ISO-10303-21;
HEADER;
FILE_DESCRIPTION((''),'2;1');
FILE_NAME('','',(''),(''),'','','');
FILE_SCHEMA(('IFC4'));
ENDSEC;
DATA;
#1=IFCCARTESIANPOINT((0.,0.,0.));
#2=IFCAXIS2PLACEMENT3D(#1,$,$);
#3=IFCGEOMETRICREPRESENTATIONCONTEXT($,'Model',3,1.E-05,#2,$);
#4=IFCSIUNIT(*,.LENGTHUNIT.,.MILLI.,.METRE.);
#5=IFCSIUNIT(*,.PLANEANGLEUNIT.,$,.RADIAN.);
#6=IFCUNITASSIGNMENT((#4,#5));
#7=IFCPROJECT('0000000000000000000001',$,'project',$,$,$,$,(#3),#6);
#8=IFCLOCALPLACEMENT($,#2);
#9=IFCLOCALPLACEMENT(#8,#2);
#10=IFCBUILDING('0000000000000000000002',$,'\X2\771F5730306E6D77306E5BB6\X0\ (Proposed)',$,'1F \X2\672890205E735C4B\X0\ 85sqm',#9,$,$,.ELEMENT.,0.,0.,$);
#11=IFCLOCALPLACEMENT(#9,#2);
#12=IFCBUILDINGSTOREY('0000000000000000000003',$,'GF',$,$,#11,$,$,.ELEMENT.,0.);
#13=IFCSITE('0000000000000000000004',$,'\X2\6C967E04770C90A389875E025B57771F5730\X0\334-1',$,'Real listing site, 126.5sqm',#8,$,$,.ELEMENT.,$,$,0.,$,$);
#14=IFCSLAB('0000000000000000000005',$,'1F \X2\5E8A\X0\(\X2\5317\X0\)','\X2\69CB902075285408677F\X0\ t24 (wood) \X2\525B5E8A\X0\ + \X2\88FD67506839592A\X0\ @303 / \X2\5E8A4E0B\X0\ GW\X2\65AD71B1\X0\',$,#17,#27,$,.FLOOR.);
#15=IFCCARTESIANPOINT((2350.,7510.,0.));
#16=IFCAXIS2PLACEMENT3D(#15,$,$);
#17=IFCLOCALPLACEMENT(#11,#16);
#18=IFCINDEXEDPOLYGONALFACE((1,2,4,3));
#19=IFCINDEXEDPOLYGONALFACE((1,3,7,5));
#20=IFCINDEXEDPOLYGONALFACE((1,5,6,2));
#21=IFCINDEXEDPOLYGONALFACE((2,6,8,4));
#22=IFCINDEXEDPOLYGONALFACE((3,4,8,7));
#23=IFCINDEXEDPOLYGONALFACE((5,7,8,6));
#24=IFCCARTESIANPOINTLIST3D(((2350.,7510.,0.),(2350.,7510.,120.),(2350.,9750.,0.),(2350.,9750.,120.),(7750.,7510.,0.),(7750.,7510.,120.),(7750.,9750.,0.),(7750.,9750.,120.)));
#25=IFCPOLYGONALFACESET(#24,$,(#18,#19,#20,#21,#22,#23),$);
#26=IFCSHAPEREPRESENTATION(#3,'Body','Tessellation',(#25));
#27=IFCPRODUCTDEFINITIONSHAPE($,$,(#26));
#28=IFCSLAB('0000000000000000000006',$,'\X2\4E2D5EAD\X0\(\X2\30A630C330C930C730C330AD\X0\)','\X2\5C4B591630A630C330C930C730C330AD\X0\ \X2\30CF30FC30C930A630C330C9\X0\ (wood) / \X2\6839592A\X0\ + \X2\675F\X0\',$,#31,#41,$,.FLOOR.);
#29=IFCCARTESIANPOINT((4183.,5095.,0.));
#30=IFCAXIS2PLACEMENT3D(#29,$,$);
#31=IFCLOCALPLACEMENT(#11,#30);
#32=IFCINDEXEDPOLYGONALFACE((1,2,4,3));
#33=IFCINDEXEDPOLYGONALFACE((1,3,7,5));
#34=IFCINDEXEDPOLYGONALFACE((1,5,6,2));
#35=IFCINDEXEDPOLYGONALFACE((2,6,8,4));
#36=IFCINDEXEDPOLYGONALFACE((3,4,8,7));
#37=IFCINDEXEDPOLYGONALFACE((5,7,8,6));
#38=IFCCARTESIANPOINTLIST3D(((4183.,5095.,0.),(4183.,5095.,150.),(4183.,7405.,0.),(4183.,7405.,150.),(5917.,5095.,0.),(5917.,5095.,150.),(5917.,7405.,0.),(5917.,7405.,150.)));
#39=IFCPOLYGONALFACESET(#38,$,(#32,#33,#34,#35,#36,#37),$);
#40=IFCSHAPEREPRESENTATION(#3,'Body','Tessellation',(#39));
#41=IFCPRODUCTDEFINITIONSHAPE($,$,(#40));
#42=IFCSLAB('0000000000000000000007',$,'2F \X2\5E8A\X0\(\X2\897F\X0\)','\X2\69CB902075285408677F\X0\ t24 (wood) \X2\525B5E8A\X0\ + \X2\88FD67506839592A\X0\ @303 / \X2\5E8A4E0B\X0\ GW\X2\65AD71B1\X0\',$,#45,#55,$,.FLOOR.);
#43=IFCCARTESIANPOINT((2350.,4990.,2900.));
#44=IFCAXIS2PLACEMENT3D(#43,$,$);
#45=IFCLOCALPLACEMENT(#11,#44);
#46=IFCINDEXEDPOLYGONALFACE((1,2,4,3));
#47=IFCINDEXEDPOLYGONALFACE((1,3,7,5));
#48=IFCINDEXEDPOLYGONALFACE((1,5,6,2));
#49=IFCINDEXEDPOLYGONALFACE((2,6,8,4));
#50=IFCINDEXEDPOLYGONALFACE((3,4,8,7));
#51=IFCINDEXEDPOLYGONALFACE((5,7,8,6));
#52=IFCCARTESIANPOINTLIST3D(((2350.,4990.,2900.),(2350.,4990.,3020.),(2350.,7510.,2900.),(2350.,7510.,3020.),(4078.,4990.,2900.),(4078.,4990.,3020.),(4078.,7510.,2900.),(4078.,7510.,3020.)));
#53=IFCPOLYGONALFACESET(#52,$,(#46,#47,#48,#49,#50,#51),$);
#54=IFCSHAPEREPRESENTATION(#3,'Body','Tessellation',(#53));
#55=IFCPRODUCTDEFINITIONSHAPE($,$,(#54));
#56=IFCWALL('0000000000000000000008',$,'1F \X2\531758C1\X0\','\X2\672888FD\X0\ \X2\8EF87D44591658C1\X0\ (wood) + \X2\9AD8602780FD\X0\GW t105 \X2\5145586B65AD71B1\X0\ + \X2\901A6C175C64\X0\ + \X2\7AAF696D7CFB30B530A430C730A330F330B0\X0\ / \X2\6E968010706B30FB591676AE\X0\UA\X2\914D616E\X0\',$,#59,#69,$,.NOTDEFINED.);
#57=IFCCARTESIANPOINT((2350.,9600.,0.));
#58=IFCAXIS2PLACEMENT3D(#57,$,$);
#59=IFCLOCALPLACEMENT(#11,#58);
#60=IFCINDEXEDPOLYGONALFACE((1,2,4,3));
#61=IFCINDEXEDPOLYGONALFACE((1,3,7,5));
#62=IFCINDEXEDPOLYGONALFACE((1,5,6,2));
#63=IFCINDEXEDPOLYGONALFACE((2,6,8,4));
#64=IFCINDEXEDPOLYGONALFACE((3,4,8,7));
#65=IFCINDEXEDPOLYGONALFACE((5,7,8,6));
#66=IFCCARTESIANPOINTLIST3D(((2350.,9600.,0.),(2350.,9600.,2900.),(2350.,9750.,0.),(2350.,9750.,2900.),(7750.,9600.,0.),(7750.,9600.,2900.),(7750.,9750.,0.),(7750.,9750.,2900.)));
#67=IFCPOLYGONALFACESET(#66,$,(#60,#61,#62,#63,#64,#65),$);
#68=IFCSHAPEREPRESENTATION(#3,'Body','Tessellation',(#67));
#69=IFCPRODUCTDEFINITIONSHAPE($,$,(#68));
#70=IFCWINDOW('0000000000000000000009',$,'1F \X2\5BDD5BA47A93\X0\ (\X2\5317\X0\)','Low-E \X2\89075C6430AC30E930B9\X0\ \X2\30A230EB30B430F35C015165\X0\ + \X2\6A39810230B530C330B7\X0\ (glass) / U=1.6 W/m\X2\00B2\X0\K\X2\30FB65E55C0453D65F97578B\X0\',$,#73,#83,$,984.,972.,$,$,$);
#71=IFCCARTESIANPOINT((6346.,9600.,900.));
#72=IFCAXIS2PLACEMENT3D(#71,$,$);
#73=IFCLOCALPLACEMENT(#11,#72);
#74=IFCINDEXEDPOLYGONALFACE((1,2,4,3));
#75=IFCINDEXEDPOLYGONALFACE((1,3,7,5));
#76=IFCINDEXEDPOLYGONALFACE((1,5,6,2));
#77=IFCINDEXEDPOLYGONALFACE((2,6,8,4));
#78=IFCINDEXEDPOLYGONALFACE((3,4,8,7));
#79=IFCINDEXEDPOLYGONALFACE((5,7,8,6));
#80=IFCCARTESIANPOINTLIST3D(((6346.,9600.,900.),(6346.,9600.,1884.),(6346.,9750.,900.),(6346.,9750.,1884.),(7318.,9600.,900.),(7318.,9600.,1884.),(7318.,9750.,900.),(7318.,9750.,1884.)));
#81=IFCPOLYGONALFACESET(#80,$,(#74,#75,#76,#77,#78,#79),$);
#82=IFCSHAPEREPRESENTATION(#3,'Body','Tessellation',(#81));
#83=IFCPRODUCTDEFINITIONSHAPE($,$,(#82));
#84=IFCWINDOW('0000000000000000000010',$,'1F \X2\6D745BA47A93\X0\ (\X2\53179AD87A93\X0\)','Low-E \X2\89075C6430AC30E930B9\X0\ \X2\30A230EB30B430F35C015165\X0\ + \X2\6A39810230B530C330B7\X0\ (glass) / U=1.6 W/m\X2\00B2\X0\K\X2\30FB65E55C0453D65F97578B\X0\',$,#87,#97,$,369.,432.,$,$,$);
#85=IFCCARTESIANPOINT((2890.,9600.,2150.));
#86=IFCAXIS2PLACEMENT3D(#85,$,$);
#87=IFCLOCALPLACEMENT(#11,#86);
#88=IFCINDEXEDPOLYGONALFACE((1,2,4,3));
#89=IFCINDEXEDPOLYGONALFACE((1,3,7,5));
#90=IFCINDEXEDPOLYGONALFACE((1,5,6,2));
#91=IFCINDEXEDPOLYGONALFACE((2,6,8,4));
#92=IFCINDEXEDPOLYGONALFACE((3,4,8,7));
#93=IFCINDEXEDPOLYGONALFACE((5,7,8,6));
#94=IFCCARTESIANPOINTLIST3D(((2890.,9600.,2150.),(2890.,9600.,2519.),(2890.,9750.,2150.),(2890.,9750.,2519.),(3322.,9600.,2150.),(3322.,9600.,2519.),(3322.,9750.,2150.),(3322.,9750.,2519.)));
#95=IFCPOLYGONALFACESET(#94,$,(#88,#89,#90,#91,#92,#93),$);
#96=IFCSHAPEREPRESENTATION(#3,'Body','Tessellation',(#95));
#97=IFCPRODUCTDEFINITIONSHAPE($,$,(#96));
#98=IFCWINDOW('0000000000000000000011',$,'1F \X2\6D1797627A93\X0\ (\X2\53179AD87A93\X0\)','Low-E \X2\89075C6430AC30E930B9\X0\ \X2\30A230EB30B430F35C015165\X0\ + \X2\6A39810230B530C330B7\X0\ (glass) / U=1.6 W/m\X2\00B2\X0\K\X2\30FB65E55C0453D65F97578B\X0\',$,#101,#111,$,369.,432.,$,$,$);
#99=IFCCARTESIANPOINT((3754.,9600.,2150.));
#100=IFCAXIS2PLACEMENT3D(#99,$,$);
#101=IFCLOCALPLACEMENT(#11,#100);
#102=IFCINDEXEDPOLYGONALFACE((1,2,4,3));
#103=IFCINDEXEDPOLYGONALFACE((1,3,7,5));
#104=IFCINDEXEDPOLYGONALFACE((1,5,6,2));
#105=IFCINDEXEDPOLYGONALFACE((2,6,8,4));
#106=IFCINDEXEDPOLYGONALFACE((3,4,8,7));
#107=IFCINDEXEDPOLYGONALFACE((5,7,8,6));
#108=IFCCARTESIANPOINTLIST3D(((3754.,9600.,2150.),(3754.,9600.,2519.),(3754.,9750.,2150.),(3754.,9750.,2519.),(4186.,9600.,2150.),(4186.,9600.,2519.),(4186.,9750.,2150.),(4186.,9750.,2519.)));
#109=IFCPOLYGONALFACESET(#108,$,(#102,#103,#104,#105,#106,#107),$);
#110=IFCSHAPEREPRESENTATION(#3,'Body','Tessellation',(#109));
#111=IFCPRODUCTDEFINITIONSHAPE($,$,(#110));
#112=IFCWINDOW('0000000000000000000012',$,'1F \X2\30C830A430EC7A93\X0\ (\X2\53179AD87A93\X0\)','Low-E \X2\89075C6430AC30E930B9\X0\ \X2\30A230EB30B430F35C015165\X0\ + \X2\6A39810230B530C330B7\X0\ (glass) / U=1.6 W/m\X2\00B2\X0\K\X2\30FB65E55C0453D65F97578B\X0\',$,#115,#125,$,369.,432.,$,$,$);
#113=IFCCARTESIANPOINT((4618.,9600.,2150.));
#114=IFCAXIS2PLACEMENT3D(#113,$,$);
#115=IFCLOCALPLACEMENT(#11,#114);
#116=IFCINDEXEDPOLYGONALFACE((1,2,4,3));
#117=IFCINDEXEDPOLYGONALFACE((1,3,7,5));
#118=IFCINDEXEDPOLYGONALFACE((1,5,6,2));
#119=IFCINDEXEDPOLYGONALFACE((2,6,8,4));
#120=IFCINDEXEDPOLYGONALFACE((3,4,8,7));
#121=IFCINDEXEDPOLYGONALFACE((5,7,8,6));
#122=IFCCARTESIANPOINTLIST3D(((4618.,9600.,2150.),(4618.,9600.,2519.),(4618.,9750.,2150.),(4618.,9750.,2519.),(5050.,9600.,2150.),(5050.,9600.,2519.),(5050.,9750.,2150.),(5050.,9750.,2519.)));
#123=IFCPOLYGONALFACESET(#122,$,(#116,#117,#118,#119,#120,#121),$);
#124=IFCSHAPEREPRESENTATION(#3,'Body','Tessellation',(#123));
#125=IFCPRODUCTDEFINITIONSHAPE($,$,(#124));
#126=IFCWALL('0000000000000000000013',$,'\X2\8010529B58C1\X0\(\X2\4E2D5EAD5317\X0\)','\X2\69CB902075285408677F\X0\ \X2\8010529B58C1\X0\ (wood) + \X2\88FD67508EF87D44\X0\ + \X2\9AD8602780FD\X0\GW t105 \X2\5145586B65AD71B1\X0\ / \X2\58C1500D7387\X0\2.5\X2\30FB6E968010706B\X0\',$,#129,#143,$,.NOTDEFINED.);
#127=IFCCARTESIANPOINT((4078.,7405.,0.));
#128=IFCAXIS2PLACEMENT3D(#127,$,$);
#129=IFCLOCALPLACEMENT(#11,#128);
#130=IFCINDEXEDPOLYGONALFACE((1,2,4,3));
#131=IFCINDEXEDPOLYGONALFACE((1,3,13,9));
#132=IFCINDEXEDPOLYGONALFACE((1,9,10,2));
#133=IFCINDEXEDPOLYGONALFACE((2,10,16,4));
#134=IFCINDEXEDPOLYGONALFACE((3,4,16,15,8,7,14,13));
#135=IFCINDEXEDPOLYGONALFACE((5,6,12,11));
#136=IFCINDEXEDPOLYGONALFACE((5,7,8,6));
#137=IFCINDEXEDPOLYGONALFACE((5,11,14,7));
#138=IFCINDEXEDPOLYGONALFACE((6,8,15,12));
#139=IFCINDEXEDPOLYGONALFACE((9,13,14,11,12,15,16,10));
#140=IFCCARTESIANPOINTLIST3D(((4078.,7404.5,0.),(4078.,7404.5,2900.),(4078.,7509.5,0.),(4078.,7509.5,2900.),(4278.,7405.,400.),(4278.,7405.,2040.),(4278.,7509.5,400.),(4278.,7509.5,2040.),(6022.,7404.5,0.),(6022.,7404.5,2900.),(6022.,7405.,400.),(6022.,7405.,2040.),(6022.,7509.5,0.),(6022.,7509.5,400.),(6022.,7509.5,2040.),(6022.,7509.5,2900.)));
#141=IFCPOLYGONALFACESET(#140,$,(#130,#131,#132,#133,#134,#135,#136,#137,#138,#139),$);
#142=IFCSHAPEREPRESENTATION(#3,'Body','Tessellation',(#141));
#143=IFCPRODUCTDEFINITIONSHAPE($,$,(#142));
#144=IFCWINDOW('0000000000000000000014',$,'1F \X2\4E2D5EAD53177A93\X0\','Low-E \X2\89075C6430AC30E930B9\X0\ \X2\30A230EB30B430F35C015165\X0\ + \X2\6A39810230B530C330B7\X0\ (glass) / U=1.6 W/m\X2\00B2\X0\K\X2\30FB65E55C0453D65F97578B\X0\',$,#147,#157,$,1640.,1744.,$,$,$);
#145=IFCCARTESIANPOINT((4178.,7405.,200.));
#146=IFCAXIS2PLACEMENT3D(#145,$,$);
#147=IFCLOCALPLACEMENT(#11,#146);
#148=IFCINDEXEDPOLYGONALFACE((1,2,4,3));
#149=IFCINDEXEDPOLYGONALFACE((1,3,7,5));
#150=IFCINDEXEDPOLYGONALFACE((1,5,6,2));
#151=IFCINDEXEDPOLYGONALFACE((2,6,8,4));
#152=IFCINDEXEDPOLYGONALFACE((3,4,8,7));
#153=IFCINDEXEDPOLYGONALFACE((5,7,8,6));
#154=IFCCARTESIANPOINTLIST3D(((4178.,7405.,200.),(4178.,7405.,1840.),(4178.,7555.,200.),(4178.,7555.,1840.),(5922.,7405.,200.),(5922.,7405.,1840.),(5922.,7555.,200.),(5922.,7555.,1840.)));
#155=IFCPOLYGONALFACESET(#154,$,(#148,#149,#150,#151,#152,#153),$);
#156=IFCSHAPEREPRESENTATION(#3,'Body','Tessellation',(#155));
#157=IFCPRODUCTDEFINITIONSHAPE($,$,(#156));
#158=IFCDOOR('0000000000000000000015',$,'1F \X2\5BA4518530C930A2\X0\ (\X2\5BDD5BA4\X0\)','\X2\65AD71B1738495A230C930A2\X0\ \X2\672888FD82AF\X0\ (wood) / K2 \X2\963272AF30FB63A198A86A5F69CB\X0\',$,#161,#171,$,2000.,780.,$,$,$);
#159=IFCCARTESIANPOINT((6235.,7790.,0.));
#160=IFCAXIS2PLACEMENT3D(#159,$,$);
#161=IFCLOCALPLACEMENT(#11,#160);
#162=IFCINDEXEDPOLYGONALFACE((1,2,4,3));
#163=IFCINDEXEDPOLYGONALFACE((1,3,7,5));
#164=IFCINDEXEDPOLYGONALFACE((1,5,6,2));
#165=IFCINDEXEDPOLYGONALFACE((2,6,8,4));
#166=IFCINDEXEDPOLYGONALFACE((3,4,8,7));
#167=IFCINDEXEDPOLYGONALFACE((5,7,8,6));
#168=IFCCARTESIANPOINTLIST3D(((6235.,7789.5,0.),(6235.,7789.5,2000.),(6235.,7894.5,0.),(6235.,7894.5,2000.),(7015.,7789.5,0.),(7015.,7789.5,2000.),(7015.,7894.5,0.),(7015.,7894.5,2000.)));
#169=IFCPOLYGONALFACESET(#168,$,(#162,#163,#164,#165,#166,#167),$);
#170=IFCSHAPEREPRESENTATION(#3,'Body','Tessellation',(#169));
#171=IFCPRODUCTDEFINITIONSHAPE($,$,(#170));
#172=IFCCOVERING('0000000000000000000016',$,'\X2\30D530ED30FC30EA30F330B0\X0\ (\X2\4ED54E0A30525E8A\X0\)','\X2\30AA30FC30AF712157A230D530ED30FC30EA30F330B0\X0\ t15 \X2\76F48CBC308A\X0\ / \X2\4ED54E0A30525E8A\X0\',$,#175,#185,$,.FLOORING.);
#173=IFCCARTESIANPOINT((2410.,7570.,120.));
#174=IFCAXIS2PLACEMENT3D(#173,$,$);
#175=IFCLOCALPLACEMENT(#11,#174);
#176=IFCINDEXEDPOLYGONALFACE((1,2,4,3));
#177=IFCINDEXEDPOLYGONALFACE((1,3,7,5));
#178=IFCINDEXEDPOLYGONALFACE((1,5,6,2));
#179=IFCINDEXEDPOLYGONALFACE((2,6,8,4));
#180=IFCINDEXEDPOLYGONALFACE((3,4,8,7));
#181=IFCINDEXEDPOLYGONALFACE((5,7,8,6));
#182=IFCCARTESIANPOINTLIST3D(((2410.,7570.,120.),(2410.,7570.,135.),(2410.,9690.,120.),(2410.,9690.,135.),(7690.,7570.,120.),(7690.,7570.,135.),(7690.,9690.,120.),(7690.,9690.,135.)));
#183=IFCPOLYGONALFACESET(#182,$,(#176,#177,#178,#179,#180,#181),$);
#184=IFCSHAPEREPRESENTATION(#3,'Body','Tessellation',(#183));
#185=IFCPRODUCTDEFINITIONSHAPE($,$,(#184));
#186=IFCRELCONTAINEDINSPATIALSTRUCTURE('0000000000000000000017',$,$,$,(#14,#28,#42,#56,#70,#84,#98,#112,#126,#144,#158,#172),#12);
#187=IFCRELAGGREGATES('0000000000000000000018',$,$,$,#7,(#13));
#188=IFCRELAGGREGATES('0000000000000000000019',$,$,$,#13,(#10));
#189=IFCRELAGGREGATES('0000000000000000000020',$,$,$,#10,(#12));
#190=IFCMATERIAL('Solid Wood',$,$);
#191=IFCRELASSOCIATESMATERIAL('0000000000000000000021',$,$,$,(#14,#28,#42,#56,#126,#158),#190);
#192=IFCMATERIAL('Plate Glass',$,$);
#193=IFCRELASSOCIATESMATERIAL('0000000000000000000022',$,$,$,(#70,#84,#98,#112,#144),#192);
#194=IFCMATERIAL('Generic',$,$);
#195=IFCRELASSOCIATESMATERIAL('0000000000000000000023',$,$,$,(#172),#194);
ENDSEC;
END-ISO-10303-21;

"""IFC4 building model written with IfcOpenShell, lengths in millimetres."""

from ifc_helpers import new_model, si_unit, frame, frame_2d, origin, place, context, project, spatial, rectangle, extrude, material, element, fill, save


model = new_model("IFC4")

# Units and contexts
model_context = context("Model", 3, precision=1e-05, world=origin())
ifc_project = project(units=[si_unit("LENGTHUNIT", "METRE", prefix="MILLI"), si_unit("PLANEANGLEUNIT", "RADIAN")], contexts=[model_context])

# Site, building, storey
site_placement = place(None, origin())
site = spatial("IfcSite", under=ifc_project, at=site_placement, Name="沖縄県那覇市字真地334-1", ObjectType="Real listing site, 126.5sqm", CompositionType="ELEMENT", RefElevation=0.0)
building_placement = place(site_placement, origin())
building = spatial("IfcBuilding", under=site, at=building_placement, Name="真地の海の家 (Proposed)", ObjectType="1F 木造平屋 85sqm", CompositionType="ELEMENT", ElevationOfRefHeight=0.0, ElevationOfTerrain=0.0)
storey_placement = place(building_placement, origin())
storey = spatial("IfcBuildingStorey", under=building, at=storey_placement, Name="GF", CompositionType="ELEMENT", Elevation=0.0)

# Slabs
ifc_material_1 = material(Name="Solid Wood")
slab_1_placement = place(storey_placement, frame((2350.0, 7510.0, 0.0)))
element("IfcSlab", 1, at=slab_1_placement, inside=storey, material=ifc_material_1, Name="1F 床(北)", Description="構造用合板 t24 (wood) 剛床 + 製材根太 @303 / 床下 GW断熱", PredefinedType="FLOOR", context=model_context, shape_type="SweptSolid", body=[
    extrude(rectangle(XDim=5400.0, YDim=2240.0, at=frame_2d((2700.0, 1120.0))), frame((2350.0, 7510.0, 0.0)), (0.0, 0.0, 1.0), 120.0),
])
slab_2_placement = place(storey_placement, frame((4183.0, 5095.0, 0.0)))
element("IfcSlab", 2, at=slab_2_placement, inside=storey, material=ifc_material_1, Name="中庭(ウッドデッキ)", Description="屋外ウッドデッキ ハードウッド (wood) / 根太 + 束", PredefinedType="FLOOR", context=model_context, shape_type="SweptSolid", body=[
    extrude(rectangle(XDim=1734.0, YDim=2310.0, at=frame_2d((867.0, 1155.0))), frame((4183.0, 5095.0, 0.0)), (0.0, 0.0, 1.0), 150.0),
])
slab_3_placement = place(storey_placement, frame((2350.0, 4990.0, 2900.0)))
element("IfcSlab", 3, at=slab_3_placement, inside=storey, material=ifc_material_1, Name="2F 床(西)", Description="構造用合板 t24 (wood) 剛床 + 製材根太 @303 / 床下 GW断熱", PredefinedType="FLOOR", context=model_context, shape_type="SweptSolid", body=[
    extrude(rectangle(XDim=1728.0, YDim=2520.0, at=frame_2d((864.0, 1260.0))), frame((2350.0, 4990.0, 2900.0)), (0.0, 0.0, 1.0), 120.0),
])

# Wall, openings, windows
wall_1_placement = place(storey_placement, frame((2350.0, 9600.0, 0.0)))
wall_1 = element("IfcWall", 4, at=wall_1_placement, inside=storey, material=ifc_material_1, Name="1F 北壁", Description="木製 軸組外壁 (wood) + 高性能GW t105 充填断熱 + 通気層 + 窯業系サイディング / 準耐火・外皮UA配慮", PredefinedType="NOTDEFINED", context=model_context, shape_type="SweptSolid", body=[
    extrude(rectangle(XDim=5400.0, YDim=150.0, at=frame_2d((2700.0, 75.0))), frame((2350.0, 9600.0, 0.0)), (0.0, 0.0, 1.0), 2900.0),
])
opening_1_placement = place(storey_placement, frame((6346.0, 9600.0, 900.0)))
opening_1 = element("IfcOpeningElement", 5, at=opening_1_placement, cuts=wall_1, PredefinedType="NOTDEFINED", context=model_context, shape_type="SweptSolid", body=[
    extrude(rectangle(XDim=972.0, YDim=150.0, at=frame_2d((486.0, 75.0))), frame((6346.0, 9600.0, 900.0)), (0.0, 0.0, 1.0), 984.0),
])
opening_2_placement = place(storey_placement, frame((2890.0, 9600.0, 2150.0)))
opening_2 = element("IfcOpeningElement", 6, at=opening_2_placement, cuts=wall_1, PredefinedType="NOTDEFINED", context=model_context, shape_type="SweptSolid", body=[
    extrude(rectangle(XDim=432.0, YDim=150.0, at=frame_2d((216.0, 75.0))), frame((2890.0, 9600.0, 2150.0)), (0.0, 0.0, 1.0), 369.0),
])
opening_3_placement = place(storey_placement, frame((3754.0, 9600.0, 2150.0)))
opening_3 = element("IfcOpeningElement", 7, at=opening_3_placement, cuts=wall_1, PredefinedType="NOTDEFINED", context=model_context, shape_type="SweptSolid", body=[
    extrude(rectangle(XDim=432.0, YDim=150.0, at=frame_2d((216.0, 75.0))), frame((3754.0, 9600.0, 2150.0)), (0.0, 0.0, 1.0), 369.0),
])
opening_4_placement = place(storey_placement, frame((4618.0, 9600.0, 2150.0)))
opening_4 = element("IfcOpeningElement", 8, at=opening_4_placement, cuts=wall_1, PredefinedType="NOTDEFINED", context=model_context, shape_type="SweptSolid", body=[
    extrude(rectangle(XDim=432.0, YDim=150.0, at=frame_2d((216.0, 75.0))), frame((4618.0, 9600.0, 2150.0)), (0.0, 0.0, 1.0), 369.0),
])
ifc_material_2 = material(Name="Plate Glass")
window_1_placement = place(storey_placement, frame((6346.0, 9600.0, 900.0)))
window_1 = element("IfcWindow", 9, at=window_1_placement, inside=storey, material=ifc_material_2, Name="1F 寝室窓 (北)", Description="Low-E 複層ガラス アルゴン封入 + 樹脂サッシ (glass) / U=1.6 W/m²K・日射取得型", OverallHeight=984.0, OverallWidth=972.0, context=model_context, shape_type="SweptSolid", body=[
    extrude(rectangle(XDim=972.0, YDim=150.0, at=frame_2d((486.0, 75.0))), frame((6346.0, 9600.0, 900.0)), (0.0, 0.0, 1.0), 984.0),
])
fill(opening_1, window_1)
window_2_placement = place(storey_placement, frame((2890.0, 9600.0, 2150.0)))
window_2 = element("IfcWindow", 10, at=window_2_placement, inside=storey, material=ifc_material_2, Name="1F 浴室窓 (北高窓)", Description="Low-E 複層ガラス アルゴン封入 + 樹脂サッシ (glass) / U=1.6 W/m²K・日射取得型", OverallHeight=369.0, OverallWidth=432.0, context=model_context, shape_type="SweptSolid", body=[
    extrude(rectangle(XDim=432.0, YDim=150.0, at=frame_2d((216.0, 75.0))), frame((2890.0, 9600.0, 2150.0)), (0.0, 0.0, 1.0), 369.0),
])
fill(opening_2, window_2)
window_3_placement = place(storey_placement, frame((3754.0, 9600.0, 2150.0)))
window_3 = element("IfcWindow", 11, at=window_3_placement, inside=storey, material=ifc_material_2, Name="1F 洗面窓 (北高窓)", Description="Low-E 複層ガラス アルゴン封入 + 樹脂サッシ (glass) / U=1.6 W/m²K・日射取得型", OverallHeight=369.0, OverallWidth=432.0, context=model_context, shape_type="SweptSolid", body=[
    extrude(rectangle(XDim=432.0, YDim=150.0, at=frame_2d((216.0, 75.0))), frame((3754.0, 9600.0, 2150.0)), (0.0, 0.0, 1.0), 369.0),
])
fill(opening_3, window_3)
window_4_placement = place(storey_placement, frame((4618.0, 9600.0, 2150.0)))
window_4 = element("IfcWindow", 12, at=window_4_placement, inside=storey, material=ifc_material_2, Name="1F トイレ窓 (北高窓)", Description="Low-E 複層ガラス アルゴン封入 + 樹脂サッシ (glass) / U=1.6 W/m²K・日射取得型", OverallHeight=369.0, OverallWidth=432.0, context=model_context, shape_type="SweptSolid", body=[
    extrude(rectangle(XDim=432.0, YDim=150.0, at=frame_2d((216.0, 75.0))), frame((4618.0, 9600.0, 2150.0)), (0.0, 0.0, 1.0), 369.0),
])
fill(opening_4, window_4)

# Wall, opening, window
wall_2_placement = place(storey_placement, frame((4078.0, 7405.0, 0.0)))
wall_2 = element("IfcWall", 13, at=wall_2_placement, inside=storey, material=ifc_material_1, Name="耐力壁(中庭北)", Description="構造用合板 耐力壁 (wood) + 製材軸組 + 高性能GW t105 充填断熱 / 壁倍率2.5・準耐火", PredefinedType="NOTDEFINED", context=model_context, shape_type="SweptSolid", body=[
    extrude(rectangle(XDim=1944.0, YDim=105.0, at=frame_2d((972.0, 52.0))), frame((4078.0, 7405.0, 0.0)), (0.0, 0.0, 1.0), 2900.0),
])
opening_5_placement = place(storey_placement, frame((4178.0, 7405.0, 200.0)))
opening_5 = element("IfcOpeningElement", 14, at=opening_5_placement, cuts=wall_2, PredefinedType="NOTDEFINED", context=model_context, shape_type="SweptSolid", body=[
    extrude(rectangle(XDim=1744.0, YDim=150.0, at=frame_2d((872.0, 75.0))), frame((4178.0, 7405.0, 200.0)), (0.0, 0.0, 1.0), 1640.0),
])
window_5_placement = place(storey_placement, frame((4178.0, 7405.0, 200.0)))
window_5 = element("IfcWindow", 15, at=window_5_placement, inside=storey, material=ifc_material_2, Name="1F 中庭北窓", Description="Low-E 複層ガラス アルゴン封入 + 樹脂サッシ (glass) / U=1.6 W/m²K・日射取得型", OverallHeight=1640.0, OverallWidth=1744.0, context=model_context, shape_type="SweptSolid", body=[
    extrude(rectangle(XDim=1744.0, YDim=150.0, at=frame_2d((872.0, 75.0))), frame((4178.0, 7405.0, 200.0)), (0.0, 0.0, 1.0), 1640.0),
])
fill(opening_5, window_5)

# Door
door_1_placement = place(storey_placement, frame((6235.0, 7790.0, 0.0)))
element("IfcDoor", 16, at=door_1_placement, inside=storey, material=ifc_material_1, Name="1F 室内ドア (寝室)", Description="断熱玄関ドア 木製芯 (wood) / K2 防犯・採風機構", OverallHeight=2000.0, OverallWidth=780.0, context=model_context, shape_type="SweptSolid", body=[
    extrude(rectangle(XDim=780.0, YDim=105.0, at=frame_2d((390.0, 52.0))), frame((6235.0, 7790.0, 0.0)), (0.0, 0.0, 1.0), 2000.0),
])

# Covering
ifc_material_3 = material(Name="Generic")
covering_1_placement = place(storey_placement, frame((2410.0, 7570.0, 120.0)))
element("IfcCovering", 17, at=covering_1_placement, inside=storey, material=ifc_material_3, Name="フローリング (仕上げ床)", Description="オーク無垢フローリング t15 直貼り / 仕上げ床", PredefinedType="FLOORING", context=model_context, shape_type="SweptSolid", body=[
    extrude(rectangle(XDim=5280.0, YDim=2120.0, at=frame_2d((2640.0, 1060.0))), frame((2410.0, 7570.0, 120.0)), (0.0, 0.0, 1.0), 15.0),
])

save(model, "model.ifc")
